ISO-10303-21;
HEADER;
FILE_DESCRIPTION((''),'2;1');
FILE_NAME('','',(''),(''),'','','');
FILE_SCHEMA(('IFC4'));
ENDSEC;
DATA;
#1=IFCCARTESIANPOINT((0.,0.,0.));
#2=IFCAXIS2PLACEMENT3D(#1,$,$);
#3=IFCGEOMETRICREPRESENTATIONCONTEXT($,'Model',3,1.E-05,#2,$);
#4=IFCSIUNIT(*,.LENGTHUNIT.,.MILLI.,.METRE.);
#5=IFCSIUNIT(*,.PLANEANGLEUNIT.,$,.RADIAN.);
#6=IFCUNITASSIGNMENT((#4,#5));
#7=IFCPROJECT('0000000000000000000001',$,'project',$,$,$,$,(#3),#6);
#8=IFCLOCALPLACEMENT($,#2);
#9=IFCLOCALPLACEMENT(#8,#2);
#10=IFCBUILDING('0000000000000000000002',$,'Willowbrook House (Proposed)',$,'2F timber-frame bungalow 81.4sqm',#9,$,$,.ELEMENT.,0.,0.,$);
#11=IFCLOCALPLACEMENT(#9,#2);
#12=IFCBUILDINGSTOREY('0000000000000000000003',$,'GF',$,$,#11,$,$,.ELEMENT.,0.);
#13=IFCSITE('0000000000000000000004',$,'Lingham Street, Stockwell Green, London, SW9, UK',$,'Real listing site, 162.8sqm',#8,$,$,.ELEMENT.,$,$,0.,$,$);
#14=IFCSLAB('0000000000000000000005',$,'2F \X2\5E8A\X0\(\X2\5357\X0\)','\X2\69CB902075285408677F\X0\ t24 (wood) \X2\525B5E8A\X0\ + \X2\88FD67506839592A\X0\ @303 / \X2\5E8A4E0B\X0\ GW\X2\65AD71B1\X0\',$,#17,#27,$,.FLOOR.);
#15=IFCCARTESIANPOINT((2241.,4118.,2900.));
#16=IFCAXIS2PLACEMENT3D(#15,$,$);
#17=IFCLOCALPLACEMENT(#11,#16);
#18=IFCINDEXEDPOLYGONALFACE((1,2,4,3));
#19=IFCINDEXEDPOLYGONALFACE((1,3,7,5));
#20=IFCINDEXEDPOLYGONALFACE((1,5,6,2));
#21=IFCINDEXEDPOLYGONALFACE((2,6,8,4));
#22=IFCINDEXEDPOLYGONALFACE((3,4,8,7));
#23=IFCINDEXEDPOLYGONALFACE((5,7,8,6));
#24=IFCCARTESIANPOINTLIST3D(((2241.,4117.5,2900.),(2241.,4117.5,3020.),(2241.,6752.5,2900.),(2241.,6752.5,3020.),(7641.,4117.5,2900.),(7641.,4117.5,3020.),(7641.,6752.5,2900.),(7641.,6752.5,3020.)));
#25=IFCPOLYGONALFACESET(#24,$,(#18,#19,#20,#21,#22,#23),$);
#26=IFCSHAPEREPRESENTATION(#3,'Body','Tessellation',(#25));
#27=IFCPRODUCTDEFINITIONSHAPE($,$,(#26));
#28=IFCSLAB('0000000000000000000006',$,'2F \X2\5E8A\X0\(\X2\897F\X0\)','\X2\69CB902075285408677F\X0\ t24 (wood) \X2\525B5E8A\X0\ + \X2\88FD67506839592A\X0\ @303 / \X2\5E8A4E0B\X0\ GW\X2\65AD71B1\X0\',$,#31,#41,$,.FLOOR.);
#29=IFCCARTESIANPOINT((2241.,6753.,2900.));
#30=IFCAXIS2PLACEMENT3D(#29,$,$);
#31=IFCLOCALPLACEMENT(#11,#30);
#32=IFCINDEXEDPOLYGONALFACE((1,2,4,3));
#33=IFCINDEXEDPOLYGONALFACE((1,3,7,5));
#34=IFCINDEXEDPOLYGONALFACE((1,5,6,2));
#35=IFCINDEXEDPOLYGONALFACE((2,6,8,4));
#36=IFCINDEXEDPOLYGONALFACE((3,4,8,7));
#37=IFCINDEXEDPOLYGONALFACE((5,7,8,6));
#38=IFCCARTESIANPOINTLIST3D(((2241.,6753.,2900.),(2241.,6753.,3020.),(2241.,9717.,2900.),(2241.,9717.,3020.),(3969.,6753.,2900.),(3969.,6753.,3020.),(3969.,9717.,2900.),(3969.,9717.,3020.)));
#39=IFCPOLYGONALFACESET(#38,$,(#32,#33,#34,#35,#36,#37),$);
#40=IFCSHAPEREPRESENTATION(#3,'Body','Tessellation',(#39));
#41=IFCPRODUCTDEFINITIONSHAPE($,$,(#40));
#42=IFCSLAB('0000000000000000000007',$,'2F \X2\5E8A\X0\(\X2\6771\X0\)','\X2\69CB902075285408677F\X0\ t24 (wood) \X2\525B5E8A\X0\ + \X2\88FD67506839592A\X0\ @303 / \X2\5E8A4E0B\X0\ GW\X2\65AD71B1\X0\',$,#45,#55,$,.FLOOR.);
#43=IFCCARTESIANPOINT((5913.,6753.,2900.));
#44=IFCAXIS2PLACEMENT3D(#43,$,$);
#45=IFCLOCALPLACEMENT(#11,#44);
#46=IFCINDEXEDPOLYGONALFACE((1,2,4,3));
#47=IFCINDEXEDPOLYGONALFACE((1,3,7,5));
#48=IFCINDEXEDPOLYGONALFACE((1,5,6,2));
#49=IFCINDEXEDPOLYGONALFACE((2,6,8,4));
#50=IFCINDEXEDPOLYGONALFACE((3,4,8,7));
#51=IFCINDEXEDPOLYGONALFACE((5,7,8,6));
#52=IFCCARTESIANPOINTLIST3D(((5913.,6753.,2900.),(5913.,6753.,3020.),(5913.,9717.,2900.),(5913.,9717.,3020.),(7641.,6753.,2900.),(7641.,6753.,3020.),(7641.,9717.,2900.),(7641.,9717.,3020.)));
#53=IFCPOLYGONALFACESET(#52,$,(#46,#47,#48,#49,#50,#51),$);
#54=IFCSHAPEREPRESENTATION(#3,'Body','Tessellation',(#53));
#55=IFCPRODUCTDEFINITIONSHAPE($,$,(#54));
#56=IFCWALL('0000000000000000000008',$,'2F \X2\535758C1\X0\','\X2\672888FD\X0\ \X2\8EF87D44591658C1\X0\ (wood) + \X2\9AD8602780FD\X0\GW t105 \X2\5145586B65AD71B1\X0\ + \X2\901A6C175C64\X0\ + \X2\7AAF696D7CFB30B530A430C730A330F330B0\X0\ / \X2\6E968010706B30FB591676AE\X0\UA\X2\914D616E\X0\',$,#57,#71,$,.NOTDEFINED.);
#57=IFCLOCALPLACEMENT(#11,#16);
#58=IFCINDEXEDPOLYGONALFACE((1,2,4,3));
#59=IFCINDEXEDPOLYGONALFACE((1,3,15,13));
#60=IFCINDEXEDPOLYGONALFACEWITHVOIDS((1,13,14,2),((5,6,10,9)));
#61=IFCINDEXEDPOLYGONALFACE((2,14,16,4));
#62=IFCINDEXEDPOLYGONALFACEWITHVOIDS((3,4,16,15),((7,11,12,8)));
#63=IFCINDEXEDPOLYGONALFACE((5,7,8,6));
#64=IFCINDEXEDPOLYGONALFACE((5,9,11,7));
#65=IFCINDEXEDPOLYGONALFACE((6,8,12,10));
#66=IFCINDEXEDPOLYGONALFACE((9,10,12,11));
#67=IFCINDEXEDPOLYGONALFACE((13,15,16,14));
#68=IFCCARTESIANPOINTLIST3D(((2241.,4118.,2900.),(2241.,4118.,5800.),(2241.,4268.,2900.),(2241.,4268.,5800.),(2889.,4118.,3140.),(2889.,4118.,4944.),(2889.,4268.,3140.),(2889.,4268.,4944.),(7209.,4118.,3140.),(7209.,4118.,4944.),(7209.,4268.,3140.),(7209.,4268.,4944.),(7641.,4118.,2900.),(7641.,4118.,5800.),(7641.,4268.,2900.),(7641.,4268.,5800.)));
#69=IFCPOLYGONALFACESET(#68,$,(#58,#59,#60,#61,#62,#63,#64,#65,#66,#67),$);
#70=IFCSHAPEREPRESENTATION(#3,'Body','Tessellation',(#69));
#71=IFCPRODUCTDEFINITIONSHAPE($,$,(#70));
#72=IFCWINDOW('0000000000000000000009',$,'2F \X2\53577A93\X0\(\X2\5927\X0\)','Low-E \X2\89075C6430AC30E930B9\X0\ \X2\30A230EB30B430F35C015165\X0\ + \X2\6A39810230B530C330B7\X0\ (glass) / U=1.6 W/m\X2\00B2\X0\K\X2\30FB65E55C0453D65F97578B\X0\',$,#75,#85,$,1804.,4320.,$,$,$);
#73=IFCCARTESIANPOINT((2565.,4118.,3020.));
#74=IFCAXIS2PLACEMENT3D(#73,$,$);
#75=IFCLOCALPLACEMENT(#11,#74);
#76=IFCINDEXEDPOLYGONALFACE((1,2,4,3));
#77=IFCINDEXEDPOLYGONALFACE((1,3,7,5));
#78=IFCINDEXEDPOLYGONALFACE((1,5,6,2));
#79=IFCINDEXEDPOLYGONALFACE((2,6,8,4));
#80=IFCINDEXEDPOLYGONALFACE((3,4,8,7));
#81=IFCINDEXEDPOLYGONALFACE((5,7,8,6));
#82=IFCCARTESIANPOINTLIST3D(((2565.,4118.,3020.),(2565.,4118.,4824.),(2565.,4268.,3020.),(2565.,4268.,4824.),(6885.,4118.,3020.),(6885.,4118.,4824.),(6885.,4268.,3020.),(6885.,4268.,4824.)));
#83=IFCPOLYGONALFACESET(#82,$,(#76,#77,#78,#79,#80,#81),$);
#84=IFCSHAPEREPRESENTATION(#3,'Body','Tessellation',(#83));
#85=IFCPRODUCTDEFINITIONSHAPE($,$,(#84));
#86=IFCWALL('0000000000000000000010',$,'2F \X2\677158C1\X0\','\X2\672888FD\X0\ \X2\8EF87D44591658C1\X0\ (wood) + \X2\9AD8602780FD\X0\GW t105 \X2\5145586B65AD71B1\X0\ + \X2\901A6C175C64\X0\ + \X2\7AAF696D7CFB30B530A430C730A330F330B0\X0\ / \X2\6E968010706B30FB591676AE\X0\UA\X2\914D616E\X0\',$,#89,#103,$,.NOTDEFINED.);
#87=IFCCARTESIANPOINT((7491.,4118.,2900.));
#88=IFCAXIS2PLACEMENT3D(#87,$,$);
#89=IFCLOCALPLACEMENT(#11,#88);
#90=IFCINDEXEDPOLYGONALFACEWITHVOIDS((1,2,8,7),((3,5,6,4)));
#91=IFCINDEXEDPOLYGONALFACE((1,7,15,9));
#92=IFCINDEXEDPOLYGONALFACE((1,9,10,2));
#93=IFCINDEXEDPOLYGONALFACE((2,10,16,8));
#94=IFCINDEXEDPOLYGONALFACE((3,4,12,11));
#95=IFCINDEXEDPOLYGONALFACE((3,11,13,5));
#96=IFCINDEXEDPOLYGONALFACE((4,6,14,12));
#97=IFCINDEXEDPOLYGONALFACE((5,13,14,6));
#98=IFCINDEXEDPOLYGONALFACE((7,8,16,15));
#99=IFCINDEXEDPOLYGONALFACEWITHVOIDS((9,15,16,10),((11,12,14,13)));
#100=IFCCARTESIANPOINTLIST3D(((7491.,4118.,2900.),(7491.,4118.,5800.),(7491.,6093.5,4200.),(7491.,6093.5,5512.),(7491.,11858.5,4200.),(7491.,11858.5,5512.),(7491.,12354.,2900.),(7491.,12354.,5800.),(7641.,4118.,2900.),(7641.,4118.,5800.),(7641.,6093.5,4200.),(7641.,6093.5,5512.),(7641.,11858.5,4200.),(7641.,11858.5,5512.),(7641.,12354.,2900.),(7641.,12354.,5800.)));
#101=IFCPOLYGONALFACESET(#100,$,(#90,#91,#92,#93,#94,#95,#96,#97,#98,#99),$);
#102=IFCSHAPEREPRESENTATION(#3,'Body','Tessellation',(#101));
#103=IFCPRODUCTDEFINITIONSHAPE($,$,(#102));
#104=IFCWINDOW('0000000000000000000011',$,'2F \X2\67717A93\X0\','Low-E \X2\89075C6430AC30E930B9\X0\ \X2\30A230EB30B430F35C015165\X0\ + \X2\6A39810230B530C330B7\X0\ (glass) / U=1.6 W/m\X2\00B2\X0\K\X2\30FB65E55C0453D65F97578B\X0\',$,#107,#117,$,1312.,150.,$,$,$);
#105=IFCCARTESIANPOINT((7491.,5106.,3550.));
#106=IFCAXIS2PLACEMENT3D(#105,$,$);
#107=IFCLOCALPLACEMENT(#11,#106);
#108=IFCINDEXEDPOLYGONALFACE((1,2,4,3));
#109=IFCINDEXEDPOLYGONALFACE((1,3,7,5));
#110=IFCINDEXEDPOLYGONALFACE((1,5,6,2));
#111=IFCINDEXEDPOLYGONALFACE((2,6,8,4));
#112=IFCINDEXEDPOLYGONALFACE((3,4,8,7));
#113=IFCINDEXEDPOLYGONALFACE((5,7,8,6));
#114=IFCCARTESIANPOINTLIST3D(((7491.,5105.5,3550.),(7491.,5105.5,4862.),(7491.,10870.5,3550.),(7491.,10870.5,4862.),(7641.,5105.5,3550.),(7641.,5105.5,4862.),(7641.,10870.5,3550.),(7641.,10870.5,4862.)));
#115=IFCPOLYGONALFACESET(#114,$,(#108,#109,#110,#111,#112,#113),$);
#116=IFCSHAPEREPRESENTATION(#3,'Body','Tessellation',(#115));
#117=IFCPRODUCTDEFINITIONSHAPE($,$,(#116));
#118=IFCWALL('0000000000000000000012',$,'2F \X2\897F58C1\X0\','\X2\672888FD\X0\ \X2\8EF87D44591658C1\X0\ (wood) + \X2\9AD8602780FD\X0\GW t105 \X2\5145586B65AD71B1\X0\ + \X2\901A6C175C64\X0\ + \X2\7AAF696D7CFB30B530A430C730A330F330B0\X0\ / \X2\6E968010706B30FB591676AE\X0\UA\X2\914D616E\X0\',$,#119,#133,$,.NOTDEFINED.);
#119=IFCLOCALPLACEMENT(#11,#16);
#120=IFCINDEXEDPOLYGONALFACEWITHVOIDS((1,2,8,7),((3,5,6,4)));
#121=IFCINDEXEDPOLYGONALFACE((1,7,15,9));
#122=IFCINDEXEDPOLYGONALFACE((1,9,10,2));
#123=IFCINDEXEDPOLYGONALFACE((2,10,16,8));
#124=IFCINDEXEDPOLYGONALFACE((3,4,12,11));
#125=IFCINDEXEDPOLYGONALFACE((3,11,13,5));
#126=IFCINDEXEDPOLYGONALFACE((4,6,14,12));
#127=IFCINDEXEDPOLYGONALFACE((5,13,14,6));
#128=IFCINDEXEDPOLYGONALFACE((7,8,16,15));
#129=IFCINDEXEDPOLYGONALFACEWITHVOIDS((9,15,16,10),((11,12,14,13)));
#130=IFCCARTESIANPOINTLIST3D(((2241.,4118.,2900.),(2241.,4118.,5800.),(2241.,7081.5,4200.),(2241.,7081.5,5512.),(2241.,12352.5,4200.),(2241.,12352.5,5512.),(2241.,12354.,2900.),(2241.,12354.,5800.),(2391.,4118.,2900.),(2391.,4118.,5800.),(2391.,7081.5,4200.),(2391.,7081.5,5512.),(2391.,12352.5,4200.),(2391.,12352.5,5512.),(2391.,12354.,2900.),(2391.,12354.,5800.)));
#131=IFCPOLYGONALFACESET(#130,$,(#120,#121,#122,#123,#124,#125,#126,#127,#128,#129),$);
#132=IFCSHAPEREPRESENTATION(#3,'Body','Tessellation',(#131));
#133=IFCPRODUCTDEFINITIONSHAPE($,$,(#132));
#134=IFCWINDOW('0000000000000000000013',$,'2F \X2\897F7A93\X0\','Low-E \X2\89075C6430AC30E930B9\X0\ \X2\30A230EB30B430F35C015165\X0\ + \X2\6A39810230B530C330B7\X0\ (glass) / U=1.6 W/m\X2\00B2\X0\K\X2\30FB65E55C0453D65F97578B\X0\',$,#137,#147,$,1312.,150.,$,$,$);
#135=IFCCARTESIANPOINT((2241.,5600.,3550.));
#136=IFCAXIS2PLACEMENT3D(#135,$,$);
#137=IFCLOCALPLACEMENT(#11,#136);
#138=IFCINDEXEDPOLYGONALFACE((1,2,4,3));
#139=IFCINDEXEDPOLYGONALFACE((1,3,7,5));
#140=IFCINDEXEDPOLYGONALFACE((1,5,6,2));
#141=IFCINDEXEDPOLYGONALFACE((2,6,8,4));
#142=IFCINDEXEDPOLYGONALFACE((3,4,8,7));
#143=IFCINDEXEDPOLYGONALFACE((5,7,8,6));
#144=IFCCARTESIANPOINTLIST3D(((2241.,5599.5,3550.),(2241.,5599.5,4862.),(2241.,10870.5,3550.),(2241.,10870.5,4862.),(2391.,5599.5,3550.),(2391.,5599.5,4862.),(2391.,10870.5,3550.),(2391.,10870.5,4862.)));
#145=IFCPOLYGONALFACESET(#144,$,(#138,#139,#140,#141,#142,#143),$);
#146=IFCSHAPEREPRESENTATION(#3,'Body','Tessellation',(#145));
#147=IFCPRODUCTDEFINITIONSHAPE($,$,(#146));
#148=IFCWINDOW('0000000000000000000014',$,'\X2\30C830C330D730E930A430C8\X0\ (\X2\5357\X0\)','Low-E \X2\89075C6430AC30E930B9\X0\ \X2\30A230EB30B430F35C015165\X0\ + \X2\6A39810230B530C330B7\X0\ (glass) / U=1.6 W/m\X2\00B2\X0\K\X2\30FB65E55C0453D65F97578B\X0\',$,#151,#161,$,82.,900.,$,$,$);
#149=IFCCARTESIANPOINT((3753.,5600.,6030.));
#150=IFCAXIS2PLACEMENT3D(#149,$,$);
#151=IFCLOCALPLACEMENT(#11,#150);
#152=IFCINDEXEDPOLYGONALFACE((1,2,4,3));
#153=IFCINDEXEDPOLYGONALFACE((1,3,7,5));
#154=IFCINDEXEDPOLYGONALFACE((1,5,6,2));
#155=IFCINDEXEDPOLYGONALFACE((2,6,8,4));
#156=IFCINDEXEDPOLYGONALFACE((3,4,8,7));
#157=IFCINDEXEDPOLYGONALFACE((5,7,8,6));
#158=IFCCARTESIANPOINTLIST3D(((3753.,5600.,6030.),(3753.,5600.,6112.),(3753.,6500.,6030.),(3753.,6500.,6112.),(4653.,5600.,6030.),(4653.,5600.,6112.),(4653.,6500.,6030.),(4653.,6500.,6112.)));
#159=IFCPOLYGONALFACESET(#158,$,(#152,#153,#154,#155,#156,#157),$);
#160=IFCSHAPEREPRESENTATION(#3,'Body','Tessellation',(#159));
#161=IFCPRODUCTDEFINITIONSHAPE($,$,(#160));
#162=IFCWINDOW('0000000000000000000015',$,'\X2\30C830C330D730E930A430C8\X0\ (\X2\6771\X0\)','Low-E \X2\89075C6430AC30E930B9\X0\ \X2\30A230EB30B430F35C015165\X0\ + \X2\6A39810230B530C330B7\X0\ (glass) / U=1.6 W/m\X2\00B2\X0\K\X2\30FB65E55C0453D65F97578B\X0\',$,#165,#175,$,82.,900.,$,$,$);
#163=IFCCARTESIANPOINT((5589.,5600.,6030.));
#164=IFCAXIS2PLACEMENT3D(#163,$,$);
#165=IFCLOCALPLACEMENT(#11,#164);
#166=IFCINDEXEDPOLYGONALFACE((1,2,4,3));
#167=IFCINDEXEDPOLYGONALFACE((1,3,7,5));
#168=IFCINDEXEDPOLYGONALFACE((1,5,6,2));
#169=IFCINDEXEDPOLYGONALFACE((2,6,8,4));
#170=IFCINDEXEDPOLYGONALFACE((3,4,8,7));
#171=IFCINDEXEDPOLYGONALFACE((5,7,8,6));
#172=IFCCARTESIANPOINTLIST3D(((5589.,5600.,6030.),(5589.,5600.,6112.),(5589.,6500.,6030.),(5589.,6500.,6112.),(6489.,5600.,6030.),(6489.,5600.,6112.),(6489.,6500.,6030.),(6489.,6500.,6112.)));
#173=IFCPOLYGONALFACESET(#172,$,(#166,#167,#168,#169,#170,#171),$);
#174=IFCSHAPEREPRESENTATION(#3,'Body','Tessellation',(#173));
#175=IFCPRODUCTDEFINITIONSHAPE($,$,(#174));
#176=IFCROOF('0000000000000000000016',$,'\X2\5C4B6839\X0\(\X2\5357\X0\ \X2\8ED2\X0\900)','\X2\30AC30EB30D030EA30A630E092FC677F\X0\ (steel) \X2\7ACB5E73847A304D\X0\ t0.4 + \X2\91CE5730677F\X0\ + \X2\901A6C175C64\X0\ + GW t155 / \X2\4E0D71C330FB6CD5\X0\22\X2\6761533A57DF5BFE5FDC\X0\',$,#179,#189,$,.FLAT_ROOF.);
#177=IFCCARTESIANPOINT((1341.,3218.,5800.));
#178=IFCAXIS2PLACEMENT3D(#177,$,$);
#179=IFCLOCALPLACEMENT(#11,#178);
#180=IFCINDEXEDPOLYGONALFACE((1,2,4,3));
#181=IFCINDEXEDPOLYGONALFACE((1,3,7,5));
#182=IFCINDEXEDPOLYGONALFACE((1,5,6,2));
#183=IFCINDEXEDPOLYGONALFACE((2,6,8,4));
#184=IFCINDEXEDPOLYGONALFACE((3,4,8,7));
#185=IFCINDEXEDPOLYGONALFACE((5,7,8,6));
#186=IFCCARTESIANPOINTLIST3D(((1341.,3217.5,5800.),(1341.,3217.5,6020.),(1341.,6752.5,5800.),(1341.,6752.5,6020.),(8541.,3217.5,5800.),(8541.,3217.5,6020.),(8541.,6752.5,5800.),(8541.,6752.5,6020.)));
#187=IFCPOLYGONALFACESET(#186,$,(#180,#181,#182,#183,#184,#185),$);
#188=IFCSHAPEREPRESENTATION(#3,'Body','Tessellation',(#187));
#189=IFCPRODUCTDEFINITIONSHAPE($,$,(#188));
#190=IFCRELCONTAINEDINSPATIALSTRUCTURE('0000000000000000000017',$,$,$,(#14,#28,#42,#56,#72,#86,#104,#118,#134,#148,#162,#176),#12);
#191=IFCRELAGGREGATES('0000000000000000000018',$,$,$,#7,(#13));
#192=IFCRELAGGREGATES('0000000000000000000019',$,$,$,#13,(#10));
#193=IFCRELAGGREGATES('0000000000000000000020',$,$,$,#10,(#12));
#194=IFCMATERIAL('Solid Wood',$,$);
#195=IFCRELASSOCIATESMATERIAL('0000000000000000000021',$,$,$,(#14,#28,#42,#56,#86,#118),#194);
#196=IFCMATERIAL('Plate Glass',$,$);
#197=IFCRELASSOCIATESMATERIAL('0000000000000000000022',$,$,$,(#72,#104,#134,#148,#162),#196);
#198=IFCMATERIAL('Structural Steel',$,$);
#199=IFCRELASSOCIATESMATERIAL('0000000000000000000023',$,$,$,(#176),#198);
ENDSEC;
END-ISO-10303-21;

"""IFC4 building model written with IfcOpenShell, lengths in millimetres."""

from ifc_helpers import new_model, si_unit, frame, frame_2d, origin, place, context, project, spatial, rectangle, extrude, material, element, fill, save


model = new_model("IFC4")

# Units and contexts
model_context = context("Model", 3, precision=1e-05, world=origin())
ifc_project = project(units=[si_unit("LENGTHUNIT", "METRE", prefix="MILLI"), si_unit("PLANEANGLEUNIT", "RADIAN")], contexts=[model_context])

# Site, building, storey
site_placement = place(None, origin())
site = spatial("IfcSite", under=ifc_project, at=site_placement, Name="Lingham Street, Stockwell Green, London, SW9, UK", ObjectType="Real listing site, 162.8sqm", CompositionType="ELEMENT", RefElevation=0.0)
building_placement = place(site_placement, origin())
building = spatial("IfcBuilding", under=site, at=building_placement, Name="Willowbrook House (Proposed)", ObjectType="2F timber-frame bungalow 81.4sqm", CompositionType="ELEMENT", ElevationOfRefHeight=0.0, ElevationOfTerrain=0.0)
storey_placement = place(building_placement, origin())
storey = spatial("IfcBuildingStorey", under=building, at=storey_placement, Name="GF", CompositionType="ELEMENT", Elevation=0.0)

# Slabs
ifc_material_1 = material(Name="Solid Wood")
slab_1_placement = place(storey_placement, frame((2241.0, 4118.0, 2900.0)))
element("IfcSlab", 1, at=slab_1_placement, inside=storey, material=ifc_material_1, Name="2F 床(南)", Description="構造用合板 t24 (wood) 剛床 + 製材根太 @303 / 床下 GW断熱", PredefinedType="FLOOR", context=model_context, shape_type="SweptSolid", body=[
    extrude(rectangle(XDim=5400.0, YDim=2635.0, at=frame_2d((2700.0, 1317.0))), frame((2241.0, 4118.0, 2900.0)), (0.0, 0.0, 1.0), 120.0),
])
slab_2_placement = place(storey_placement, frame((2241.0, 6753.0, 2900.0)))
element("IfcSlab", 2, at=slab_2_placement, inside=storey, material=ifc_material_1, Name="2F 床(西)", Description="構造用合板 t24 (wood) 剛床 + 製材根太 @303 / 床下 GW断熱", PredefinedType="FLOOR", context=model_context, shape_type="SweptSolid", body=[
    extrude(rectangle(XDim=1728.0, YDim=2964.0, at=frame_2d((864.0, 1482.0))), frame((2241.0, 6753.0, 2900.0)), (0.0, 0.0, 1.0), 120.0),
])
slab_3_placement = place(storey_placement, frame((5913.0, 6753.0, 2900.0)))
element("IfcSlab", 3, at=slab_3_placement, inside=storey, material=ifc_material_1, Name="2F 床(東)", Description="構造用合板 t24 (wood) 剛床 + 製材根太 @303 / 床下 GW断熱", PredefinedType="FLOOR", context=model_context, shape_type="SweptSolid", body=[
    extrude(rectangle(XDim=1728.0, YDim=2964.0, at=frame_2d((864.0, 1482.0))), frame((5913.0, 6753.0, 2900.0)), (0.0, 0.0, 1.0), 120.0),
])

# Walls, openings, windows
wall_1_placement = place(storey_placement, frame((2241.0, 4118.0, 2900.0)))
wall_1 = element("IfcWall", 4, at=wall_1_placement, inside=storey, material=ifc_material_1, Name="2F 南壁", Description="木製 軸組外壁 (wood) + 高性能GW t105 充填断熱 + 通気層 + 窯業系サイディング / 準耐火・外皮UA配慮", PredefinedType="NOTDEFINED", context=model_context, shape_type="SweptSolid", body=[
    extrude(rectangle(XDim=5400.0, YDim=150.0, at=frame_2d((2700.0, 75.0))), frame((2241.0, 4118.0, 2900.0)), (0.0, 0.0, 1.0), 2900.0),
])
opening_1_placement = place(storey_placement, frame((2565.0, 4118.0, 3020.0)))
opening_1 = element("IfcOpeningElement", 5, at=opening_1_placement, cuts=wall_1, PredefinedType="NOTDEFINED", context=model_context, shape_type="SweptSolid", body=[
    extrude(rectangle(XDim=4320.0, YDim=150.0, at=frame_2d((2160.0, 75.0))), frame((2565.0, 4118.0, 3020.0)), (0.0, 0.0, 1.0), 1804.0),
])
ifc_material_2 = material(Name="Plate Glass")
window_1_placement = place(storey_placement, frame((2565.0, 4118.0, 3020.0)))
window_1 = element("IfcWindow", 6, at=window_1_placement, inside=storey, material=ifc_material_2, Name="2F 南窓(大)", Description="Low-E 複層ガラス アルゴン封入 + 樹脂サッシ (glass) / U=1.6 W/m²K・日射取得型", OverallHeight=1804.0, OverallWidth=4320.0, context=model_context, shape_type="SweptSolid", body=[
    extrude(rectangle(XDim=4320.0, YDim=150.0, at=frame_2d((2160.0, 75.0))), frame((2565.0, 4118.0, 3020.0)), (0.0, 0.0, 1.0), 1804.0),
])
fill(opening_1, window_1)
wall_2_placement = place(storey_placement, frame((7491.0, 4118.0, 2900.0)))
wall_2 = element("IfcWall", 7, at=wall_2_placement, inside=storey, material=ifc_material_1, Name="2F 東壁", Description="木製 軸組外壁 (wood) + 高性能GW t105 充填断熱 + 通気層 + 窯業系サイディング / 準耐火・外皮UA配慮", PredefinedType="NOTDEFINED", context=model_context, shape_type="SweptSolid", body=[
    extrude(rectangle(XDim=150.0, YDim=8236.0, at=frame_2d((75.0, 4118.0))), frame((7491.0, 4118.0, 2900.0)), (0.0, 0.0, 1.0), 2900.0),
])
opening_2_placement = place(storey_placement, frame((7491.0, 5106.0, 3550.0)))
opening_2 = element("IfcOpeningElement", 8, at=opening_2_placement, cuts=wall_2, PredefinedType="NOTDEFINED", context=model_context, shape_type="SweptSolid", body=[
    extrude(rectangle(XDim=150.0, YDim=5765.0, at=frame_2d((75.0, 2882.0))), frame((7491.0, 5106.0, 3550.0)), (0.0, 0.0, 1.0), 1312.0),
])
window_2_placement = place(storey_placement, frame((7491.0, 5106.0, 3550.0)))
window_2 = element("IfcWindow", 9, at=window_2_placement, inside=storey, material=ifc_material_2, Name="2F 東窓", Description="Low-E 複層ガラス アルゴン封入 + 樹脂サッシ (glass) / U=1.6 W/m²K・日射取得型", OverallHeight=1312.0, OverallWidth=150.0, context=model_context, shape_type="SweptSolid", body=[
    extrude(rectangle(XDim=150.0, YDim=5765.0, at=frame_2d((75.0, 2882.0))), frame((7491.0, 5106.0, 3550.0)), (0.0, 0.0, 1.0), 1312.0),
])
fill(opening_2, window_2)
wall_3_placement = place(storey_placement, frame((2241.0, 4118.0, 2900.0)))
wall_3 = element("IfcWall", 10, at=wall_3_placement, inside=storey, material=ifc_material_1, Name="2F 西壁", Description="木製 軸組外壁 (wood) + 高性能GW t105 充填断熱 + 通気層 + 窯業系サイディング / 準耐火・外皮UA配慮", PredefinedType="NOTDEFINED", context=model_context, shape_type="SweptSolid", body=[
    extrude(rectangle(XDim=150.0, YDim=8236.0, at=frame_2d((75.0, 4118.0))), frame((2241.0, 4118.0, 2900.0)), (0.0, 0.0, 1.0), 2900.0),
])
opening_3_placement = place(storey_placement, frame((2241.0, 5600.0, 3550.0)))
opening_3 = element("IfcOpeningElement", 11, at=opening_3_placement, cuts=wall_3, PredefinedType="NOTDEFINED", context=model_context, shape_type="SweptSolid", body=[
    extrude(rectangle(XDim=150.0, YDim=5271.0, at=frame_2d((75.0, 2635.0))), frame((2241.0, 5600.0, 3550.0)), (0.0, 0.0, 1.0), 1312.0),
])
window_3_placement = place(storey_placement, frame((2241.0, 5600.0, 3550.0)))
window_3 = element("IfcWindow", 12, at=window_3_placement, inside=storey, material=ifc_material_2, Name="2F 西窓", Description="Low-E 複層ガラス アルゴン封入 + 樹脂サッシ (glass) / U=1.6 W/m²K・日射取得型", OverallHeight=1312.0, OverallWidth=150.0, context=model_context, shape_type="SweptSolid", body=[
    extrude(rectangle(XDim=150.0, YDim=5271.0, at=frame_2d((75.0, 2635.0))), frame((2241.0, 5600.0, 3550.0)), (0.0, 0.0, 1.0), 1312.0),
])
fill(opening_3, window_3)

# Windows
window_4_placement = place(storey_placement, frame((3753.0, 5600.0, 6030.0)))
element("IfcWindow", 13, at=window_4_placement, inside=storey, material=ifc_material_2, Name="トップライト (南)", Description="Low-E 複層ガラス アルゴン封入 + 樹脂サッシ (glass) / U=1.6 W/m²K・日射取得型", OverallHeight=82.0, OverallWidth=900.0, context=model_context, shape_type="SweptSolid", body=[
    extrude(rectangle(XDim=900.0, YDim=900.0, at=frame_2d((450.0, 450.0))), frame((3753.0, 5600.0, 6030.0)), (0.0, 0.0, 1.0), 82.0),
])
window_5_placement = place(storey_placement, frame((5589.0, 5600.0, 6030.0)))
element("IfcWindow", 14, at=window_5_placement, inside=storey, material=ifc_material_2, Name="トップライト (東)", Description="Low-E 複層ガラス アルゴン封入 + 樹脂サッシ (glass) / U=1.6 W/m²K・日射取得型", OverallHeight=82.0, OverallWidth=900.0, context=model_context, shape_type="SweptSolid", body=[
    extrude(rectangle(XDim=900.0, YDim=900.0, at=frame_2d((450.0, 450.0))), frame((5589.0, 5600.0, 6030.0)), (0.0, 0.0, 1.0), 82.0),
])

# Roof
ifc_material_3 = material(Name="Structural Steel")
roof_1_placement = place(storey_placement, frame((1341.0, 3218.0, 5800.0)))
element("IfcRoof", 15, at=roof_1_placement, inside=storey, material=ifc_material_3, Name="屋根(南 軒900)", Description="ガルバリウム鋼板 (steel) 立平葺き t0.4 + 野地板 + 通気層 + GW t155 / 不燃・法22条区域対応", PredefinedType="FLAT_ROOF", context=model_context, shape_type="SweptSolid", body=[
    extrude(rectangle(XDim=7200.0, YDim=3535.0, at=frame_2d((3600.0, 1767.0))), frame((1341.0, 3218.0, 5800.0)), (0.0, 0.0, 1.0), 220.0),
])

save(model, "model.ifc")
